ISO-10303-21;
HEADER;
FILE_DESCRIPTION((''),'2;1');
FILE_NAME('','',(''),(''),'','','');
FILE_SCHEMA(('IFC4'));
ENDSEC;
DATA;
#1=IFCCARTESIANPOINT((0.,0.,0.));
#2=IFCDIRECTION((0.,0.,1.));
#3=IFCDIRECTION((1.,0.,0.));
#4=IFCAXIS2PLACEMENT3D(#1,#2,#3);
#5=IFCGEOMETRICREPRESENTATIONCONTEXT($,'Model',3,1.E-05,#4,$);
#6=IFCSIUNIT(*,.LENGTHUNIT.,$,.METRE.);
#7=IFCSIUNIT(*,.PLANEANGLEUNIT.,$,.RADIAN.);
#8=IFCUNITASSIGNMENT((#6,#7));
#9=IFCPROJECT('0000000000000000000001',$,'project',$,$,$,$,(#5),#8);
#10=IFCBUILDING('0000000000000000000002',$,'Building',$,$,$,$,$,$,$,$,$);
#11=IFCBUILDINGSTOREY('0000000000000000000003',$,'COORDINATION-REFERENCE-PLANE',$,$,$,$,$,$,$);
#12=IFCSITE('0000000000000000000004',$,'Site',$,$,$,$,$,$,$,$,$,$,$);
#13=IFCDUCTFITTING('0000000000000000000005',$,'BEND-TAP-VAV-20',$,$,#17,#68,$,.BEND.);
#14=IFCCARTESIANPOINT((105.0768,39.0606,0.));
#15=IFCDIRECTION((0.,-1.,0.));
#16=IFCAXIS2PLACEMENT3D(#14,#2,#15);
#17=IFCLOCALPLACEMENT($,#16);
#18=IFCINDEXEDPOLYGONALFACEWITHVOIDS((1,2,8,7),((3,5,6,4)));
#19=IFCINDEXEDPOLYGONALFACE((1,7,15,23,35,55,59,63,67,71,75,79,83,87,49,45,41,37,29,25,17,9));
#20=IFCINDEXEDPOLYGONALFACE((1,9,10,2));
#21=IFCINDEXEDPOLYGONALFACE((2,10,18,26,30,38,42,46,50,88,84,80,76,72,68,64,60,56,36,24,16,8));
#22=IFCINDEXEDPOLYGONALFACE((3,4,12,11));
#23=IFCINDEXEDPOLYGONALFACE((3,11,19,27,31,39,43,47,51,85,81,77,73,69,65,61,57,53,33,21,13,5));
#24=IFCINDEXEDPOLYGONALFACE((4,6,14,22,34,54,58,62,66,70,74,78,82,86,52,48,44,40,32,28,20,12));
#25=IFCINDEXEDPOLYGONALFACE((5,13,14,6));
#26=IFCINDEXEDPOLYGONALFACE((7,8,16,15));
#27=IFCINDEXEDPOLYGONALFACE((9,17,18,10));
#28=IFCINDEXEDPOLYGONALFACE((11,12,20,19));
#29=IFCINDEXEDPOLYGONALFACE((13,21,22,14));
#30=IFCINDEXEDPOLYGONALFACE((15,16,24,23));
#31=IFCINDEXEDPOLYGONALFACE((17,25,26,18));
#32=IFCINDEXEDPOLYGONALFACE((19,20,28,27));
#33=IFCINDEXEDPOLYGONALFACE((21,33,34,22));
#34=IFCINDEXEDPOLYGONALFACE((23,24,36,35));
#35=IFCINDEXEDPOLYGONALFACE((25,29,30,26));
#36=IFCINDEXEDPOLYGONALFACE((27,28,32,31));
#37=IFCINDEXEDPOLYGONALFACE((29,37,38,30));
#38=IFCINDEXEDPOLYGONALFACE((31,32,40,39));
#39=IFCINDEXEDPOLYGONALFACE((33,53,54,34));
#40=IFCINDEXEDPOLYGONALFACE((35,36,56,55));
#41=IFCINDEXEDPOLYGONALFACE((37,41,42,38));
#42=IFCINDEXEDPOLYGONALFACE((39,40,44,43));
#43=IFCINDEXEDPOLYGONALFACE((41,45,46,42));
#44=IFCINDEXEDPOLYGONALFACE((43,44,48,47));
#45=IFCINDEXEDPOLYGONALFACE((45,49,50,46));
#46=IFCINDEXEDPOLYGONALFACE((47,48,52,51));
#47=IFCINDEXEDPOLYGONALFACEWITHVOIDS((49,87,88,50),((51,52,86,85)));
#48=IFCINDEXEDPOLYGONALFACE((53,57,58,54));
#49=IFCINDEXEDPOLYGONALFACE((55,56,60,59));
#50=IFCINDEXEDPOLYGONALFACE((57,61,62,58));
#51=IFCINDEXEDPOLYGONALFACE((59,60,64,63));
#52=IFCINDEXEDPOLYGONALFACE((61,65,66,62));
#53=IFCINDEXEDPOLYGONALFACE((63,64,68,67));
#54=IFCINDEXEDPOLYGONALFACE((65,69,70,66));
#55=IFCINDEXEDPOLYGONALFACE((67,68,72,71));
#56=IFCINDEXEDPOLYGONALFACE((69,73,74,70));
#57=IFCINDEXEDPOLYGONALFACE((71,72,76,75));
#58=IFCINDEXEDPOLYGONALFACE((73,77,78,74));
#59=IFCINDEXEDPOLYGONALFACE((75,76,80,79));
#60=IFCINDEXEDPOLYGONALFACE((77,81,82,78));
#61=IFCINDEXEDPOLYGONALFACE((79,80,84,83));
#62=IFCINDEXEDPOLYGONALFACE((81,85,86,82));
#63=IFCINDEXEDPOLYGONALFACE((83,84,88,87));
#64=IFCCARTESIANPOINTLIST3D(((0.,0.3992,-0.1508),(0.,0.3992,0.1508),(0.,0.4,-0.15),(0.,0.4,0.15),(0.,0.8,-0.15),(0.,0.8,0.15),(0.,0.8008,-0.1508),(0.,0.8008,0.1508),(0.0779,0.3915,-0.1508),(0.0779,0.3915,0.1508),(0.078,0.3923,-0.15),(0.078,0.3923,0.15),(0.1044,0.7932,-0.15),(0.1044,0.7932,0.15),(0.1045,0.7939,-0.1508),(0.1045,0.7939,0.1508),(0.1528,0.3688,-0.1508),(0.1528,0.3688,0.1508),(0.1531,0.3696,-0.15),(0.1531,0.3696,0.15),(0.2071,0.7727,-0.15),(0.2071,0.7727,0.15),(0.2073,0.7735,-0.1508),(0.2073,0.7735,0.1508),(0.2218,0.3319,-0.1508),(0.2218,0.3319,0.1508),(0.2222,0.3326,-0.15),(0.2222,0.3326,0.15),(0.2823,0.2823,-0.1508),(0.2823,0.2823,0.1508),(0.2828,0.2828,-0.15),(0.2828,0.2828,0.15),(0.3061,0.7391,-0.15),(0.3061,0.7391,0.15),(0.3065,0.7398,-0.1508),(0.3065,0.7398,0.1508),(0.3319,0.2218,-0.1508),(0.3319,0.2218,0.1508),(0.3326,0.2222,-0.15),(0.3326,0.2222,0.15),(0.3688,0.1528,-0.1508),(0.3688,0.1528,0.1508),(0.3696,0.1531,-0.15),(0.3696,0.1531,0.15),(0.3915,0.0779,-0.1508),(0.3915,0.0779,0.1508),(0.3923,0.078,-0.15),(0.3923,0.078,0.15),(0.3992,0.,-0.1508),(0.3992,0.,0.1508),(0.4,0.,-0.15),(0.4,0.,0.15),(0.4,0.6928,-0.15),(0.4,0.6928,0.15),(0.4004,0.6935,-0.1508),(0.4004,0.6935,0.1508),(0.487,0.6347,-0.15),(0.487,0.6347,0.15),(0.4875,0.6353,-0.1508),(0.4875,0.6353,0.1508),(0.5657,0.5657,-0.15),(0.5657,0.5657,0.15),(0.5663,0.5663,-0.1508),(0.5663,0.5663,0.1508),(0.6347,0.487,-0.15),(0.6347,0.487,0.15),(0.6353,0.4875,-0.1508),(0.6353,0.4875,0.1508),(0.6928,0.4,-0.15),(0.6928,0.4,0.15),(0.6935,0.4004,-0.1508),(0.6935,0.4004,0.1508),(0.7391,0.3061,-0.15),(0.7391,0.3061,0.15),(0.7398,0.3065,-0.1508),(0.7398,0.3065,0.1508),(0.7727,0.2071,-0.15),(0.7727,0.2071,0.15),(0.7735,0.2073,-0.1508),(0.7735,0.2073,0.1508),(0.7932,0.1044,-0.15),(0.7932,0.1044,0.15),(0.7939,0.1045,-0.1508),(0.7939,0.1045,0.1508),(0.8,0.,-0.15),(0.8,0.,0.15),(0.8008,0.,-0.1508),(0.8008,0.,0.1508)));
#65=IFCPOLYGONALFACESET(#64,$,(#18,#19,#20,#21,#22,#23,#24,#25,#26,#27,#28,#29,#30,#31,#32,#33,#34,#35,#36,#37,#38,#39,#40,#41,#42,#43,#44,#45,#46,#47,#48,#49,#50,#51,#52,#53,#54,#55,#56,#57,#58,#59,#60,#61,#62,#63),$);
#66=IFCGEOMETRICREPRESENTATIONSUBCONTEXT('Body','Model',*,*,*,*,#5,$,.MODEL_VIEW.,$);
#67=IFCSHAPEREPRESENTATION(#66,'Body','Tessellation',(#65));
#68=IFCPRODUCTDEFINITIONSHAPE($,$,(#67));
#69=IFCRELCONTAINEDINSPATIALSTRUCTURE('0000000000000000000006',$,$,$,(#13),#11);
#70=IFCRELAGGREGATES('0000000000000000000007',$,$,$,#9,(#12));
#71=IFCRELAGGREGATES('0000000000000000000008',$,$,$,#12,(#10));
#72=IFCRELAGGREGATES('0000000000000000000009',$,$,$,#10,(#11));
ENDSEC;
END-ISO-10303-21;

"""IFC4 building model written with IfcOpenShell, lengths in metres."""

from ifc_helpers import new_model, entity, si_unit, frame, origin_with_axes, place, context, subcontext, project, spatial, element, save


model = new_model("IFC4")

# Units and contexts
model_context = context("Model", 3, precision=1e-05, world=origin_with_axes())
body_context = subcontext(model_context, "Body", "Model", "MODEL_VIEW")
ifc_project = project(units=[si_unit("LENGTHUNIT", "METRE"), si_unit("PLANEANGLEUNIT", "RADIAN")], contexts=[model_context])

# Site, building, storey
site = spatial("IfcSite", under=ifc_project, Name="Site")
building = spatial("IfcBuilding", under=site, Name="Building")
storey = spatial("IfcBuildingStorey", under=building, Name="COORDINATION-REFERENCE-PLANE")

# Duct fitting
duct_fitting_1_placement = place(None, frame((105.0768, 39.0606, 0.0), z_axis=(0.0, 0.0, 1.0), x_axis=(0.0, -1.0, 0.0)))
cartesian_point_1 = entity("IfcCartesianPoint", [0.0, 0.0, 0.0])
element("IfcDuctFitting", 1, at=duct_fitting_1_placement, inside=storey, Name="BEND-TAP-VAV-20", PredefinedType="BEND", context=body_context, shape_type="SweptSolid", body=[
    entity("IfcRevolvedAreaSolid", entity("IfcRectangleHollowProfileDef", "AREA", None, entity("IfcAxis2Placement2D", entity("IfcCartesianPoint", [0.6, 0.0])), 0.4016, 0.3016, 0.0008), entity("IfcAxis2Placement3D", cartesian_point_1, entity("IfcDirection", [0.0, -1.0, 0.0]), entity("IfcDirection", [1.0, 0.0, 0.0])), entity("IfcAxis1Placement", cartesian_point_1, entity("IfcDirection", [0.0, 1.0, 0.0])), 1.570796),
])

save(model, "model.ifc")
